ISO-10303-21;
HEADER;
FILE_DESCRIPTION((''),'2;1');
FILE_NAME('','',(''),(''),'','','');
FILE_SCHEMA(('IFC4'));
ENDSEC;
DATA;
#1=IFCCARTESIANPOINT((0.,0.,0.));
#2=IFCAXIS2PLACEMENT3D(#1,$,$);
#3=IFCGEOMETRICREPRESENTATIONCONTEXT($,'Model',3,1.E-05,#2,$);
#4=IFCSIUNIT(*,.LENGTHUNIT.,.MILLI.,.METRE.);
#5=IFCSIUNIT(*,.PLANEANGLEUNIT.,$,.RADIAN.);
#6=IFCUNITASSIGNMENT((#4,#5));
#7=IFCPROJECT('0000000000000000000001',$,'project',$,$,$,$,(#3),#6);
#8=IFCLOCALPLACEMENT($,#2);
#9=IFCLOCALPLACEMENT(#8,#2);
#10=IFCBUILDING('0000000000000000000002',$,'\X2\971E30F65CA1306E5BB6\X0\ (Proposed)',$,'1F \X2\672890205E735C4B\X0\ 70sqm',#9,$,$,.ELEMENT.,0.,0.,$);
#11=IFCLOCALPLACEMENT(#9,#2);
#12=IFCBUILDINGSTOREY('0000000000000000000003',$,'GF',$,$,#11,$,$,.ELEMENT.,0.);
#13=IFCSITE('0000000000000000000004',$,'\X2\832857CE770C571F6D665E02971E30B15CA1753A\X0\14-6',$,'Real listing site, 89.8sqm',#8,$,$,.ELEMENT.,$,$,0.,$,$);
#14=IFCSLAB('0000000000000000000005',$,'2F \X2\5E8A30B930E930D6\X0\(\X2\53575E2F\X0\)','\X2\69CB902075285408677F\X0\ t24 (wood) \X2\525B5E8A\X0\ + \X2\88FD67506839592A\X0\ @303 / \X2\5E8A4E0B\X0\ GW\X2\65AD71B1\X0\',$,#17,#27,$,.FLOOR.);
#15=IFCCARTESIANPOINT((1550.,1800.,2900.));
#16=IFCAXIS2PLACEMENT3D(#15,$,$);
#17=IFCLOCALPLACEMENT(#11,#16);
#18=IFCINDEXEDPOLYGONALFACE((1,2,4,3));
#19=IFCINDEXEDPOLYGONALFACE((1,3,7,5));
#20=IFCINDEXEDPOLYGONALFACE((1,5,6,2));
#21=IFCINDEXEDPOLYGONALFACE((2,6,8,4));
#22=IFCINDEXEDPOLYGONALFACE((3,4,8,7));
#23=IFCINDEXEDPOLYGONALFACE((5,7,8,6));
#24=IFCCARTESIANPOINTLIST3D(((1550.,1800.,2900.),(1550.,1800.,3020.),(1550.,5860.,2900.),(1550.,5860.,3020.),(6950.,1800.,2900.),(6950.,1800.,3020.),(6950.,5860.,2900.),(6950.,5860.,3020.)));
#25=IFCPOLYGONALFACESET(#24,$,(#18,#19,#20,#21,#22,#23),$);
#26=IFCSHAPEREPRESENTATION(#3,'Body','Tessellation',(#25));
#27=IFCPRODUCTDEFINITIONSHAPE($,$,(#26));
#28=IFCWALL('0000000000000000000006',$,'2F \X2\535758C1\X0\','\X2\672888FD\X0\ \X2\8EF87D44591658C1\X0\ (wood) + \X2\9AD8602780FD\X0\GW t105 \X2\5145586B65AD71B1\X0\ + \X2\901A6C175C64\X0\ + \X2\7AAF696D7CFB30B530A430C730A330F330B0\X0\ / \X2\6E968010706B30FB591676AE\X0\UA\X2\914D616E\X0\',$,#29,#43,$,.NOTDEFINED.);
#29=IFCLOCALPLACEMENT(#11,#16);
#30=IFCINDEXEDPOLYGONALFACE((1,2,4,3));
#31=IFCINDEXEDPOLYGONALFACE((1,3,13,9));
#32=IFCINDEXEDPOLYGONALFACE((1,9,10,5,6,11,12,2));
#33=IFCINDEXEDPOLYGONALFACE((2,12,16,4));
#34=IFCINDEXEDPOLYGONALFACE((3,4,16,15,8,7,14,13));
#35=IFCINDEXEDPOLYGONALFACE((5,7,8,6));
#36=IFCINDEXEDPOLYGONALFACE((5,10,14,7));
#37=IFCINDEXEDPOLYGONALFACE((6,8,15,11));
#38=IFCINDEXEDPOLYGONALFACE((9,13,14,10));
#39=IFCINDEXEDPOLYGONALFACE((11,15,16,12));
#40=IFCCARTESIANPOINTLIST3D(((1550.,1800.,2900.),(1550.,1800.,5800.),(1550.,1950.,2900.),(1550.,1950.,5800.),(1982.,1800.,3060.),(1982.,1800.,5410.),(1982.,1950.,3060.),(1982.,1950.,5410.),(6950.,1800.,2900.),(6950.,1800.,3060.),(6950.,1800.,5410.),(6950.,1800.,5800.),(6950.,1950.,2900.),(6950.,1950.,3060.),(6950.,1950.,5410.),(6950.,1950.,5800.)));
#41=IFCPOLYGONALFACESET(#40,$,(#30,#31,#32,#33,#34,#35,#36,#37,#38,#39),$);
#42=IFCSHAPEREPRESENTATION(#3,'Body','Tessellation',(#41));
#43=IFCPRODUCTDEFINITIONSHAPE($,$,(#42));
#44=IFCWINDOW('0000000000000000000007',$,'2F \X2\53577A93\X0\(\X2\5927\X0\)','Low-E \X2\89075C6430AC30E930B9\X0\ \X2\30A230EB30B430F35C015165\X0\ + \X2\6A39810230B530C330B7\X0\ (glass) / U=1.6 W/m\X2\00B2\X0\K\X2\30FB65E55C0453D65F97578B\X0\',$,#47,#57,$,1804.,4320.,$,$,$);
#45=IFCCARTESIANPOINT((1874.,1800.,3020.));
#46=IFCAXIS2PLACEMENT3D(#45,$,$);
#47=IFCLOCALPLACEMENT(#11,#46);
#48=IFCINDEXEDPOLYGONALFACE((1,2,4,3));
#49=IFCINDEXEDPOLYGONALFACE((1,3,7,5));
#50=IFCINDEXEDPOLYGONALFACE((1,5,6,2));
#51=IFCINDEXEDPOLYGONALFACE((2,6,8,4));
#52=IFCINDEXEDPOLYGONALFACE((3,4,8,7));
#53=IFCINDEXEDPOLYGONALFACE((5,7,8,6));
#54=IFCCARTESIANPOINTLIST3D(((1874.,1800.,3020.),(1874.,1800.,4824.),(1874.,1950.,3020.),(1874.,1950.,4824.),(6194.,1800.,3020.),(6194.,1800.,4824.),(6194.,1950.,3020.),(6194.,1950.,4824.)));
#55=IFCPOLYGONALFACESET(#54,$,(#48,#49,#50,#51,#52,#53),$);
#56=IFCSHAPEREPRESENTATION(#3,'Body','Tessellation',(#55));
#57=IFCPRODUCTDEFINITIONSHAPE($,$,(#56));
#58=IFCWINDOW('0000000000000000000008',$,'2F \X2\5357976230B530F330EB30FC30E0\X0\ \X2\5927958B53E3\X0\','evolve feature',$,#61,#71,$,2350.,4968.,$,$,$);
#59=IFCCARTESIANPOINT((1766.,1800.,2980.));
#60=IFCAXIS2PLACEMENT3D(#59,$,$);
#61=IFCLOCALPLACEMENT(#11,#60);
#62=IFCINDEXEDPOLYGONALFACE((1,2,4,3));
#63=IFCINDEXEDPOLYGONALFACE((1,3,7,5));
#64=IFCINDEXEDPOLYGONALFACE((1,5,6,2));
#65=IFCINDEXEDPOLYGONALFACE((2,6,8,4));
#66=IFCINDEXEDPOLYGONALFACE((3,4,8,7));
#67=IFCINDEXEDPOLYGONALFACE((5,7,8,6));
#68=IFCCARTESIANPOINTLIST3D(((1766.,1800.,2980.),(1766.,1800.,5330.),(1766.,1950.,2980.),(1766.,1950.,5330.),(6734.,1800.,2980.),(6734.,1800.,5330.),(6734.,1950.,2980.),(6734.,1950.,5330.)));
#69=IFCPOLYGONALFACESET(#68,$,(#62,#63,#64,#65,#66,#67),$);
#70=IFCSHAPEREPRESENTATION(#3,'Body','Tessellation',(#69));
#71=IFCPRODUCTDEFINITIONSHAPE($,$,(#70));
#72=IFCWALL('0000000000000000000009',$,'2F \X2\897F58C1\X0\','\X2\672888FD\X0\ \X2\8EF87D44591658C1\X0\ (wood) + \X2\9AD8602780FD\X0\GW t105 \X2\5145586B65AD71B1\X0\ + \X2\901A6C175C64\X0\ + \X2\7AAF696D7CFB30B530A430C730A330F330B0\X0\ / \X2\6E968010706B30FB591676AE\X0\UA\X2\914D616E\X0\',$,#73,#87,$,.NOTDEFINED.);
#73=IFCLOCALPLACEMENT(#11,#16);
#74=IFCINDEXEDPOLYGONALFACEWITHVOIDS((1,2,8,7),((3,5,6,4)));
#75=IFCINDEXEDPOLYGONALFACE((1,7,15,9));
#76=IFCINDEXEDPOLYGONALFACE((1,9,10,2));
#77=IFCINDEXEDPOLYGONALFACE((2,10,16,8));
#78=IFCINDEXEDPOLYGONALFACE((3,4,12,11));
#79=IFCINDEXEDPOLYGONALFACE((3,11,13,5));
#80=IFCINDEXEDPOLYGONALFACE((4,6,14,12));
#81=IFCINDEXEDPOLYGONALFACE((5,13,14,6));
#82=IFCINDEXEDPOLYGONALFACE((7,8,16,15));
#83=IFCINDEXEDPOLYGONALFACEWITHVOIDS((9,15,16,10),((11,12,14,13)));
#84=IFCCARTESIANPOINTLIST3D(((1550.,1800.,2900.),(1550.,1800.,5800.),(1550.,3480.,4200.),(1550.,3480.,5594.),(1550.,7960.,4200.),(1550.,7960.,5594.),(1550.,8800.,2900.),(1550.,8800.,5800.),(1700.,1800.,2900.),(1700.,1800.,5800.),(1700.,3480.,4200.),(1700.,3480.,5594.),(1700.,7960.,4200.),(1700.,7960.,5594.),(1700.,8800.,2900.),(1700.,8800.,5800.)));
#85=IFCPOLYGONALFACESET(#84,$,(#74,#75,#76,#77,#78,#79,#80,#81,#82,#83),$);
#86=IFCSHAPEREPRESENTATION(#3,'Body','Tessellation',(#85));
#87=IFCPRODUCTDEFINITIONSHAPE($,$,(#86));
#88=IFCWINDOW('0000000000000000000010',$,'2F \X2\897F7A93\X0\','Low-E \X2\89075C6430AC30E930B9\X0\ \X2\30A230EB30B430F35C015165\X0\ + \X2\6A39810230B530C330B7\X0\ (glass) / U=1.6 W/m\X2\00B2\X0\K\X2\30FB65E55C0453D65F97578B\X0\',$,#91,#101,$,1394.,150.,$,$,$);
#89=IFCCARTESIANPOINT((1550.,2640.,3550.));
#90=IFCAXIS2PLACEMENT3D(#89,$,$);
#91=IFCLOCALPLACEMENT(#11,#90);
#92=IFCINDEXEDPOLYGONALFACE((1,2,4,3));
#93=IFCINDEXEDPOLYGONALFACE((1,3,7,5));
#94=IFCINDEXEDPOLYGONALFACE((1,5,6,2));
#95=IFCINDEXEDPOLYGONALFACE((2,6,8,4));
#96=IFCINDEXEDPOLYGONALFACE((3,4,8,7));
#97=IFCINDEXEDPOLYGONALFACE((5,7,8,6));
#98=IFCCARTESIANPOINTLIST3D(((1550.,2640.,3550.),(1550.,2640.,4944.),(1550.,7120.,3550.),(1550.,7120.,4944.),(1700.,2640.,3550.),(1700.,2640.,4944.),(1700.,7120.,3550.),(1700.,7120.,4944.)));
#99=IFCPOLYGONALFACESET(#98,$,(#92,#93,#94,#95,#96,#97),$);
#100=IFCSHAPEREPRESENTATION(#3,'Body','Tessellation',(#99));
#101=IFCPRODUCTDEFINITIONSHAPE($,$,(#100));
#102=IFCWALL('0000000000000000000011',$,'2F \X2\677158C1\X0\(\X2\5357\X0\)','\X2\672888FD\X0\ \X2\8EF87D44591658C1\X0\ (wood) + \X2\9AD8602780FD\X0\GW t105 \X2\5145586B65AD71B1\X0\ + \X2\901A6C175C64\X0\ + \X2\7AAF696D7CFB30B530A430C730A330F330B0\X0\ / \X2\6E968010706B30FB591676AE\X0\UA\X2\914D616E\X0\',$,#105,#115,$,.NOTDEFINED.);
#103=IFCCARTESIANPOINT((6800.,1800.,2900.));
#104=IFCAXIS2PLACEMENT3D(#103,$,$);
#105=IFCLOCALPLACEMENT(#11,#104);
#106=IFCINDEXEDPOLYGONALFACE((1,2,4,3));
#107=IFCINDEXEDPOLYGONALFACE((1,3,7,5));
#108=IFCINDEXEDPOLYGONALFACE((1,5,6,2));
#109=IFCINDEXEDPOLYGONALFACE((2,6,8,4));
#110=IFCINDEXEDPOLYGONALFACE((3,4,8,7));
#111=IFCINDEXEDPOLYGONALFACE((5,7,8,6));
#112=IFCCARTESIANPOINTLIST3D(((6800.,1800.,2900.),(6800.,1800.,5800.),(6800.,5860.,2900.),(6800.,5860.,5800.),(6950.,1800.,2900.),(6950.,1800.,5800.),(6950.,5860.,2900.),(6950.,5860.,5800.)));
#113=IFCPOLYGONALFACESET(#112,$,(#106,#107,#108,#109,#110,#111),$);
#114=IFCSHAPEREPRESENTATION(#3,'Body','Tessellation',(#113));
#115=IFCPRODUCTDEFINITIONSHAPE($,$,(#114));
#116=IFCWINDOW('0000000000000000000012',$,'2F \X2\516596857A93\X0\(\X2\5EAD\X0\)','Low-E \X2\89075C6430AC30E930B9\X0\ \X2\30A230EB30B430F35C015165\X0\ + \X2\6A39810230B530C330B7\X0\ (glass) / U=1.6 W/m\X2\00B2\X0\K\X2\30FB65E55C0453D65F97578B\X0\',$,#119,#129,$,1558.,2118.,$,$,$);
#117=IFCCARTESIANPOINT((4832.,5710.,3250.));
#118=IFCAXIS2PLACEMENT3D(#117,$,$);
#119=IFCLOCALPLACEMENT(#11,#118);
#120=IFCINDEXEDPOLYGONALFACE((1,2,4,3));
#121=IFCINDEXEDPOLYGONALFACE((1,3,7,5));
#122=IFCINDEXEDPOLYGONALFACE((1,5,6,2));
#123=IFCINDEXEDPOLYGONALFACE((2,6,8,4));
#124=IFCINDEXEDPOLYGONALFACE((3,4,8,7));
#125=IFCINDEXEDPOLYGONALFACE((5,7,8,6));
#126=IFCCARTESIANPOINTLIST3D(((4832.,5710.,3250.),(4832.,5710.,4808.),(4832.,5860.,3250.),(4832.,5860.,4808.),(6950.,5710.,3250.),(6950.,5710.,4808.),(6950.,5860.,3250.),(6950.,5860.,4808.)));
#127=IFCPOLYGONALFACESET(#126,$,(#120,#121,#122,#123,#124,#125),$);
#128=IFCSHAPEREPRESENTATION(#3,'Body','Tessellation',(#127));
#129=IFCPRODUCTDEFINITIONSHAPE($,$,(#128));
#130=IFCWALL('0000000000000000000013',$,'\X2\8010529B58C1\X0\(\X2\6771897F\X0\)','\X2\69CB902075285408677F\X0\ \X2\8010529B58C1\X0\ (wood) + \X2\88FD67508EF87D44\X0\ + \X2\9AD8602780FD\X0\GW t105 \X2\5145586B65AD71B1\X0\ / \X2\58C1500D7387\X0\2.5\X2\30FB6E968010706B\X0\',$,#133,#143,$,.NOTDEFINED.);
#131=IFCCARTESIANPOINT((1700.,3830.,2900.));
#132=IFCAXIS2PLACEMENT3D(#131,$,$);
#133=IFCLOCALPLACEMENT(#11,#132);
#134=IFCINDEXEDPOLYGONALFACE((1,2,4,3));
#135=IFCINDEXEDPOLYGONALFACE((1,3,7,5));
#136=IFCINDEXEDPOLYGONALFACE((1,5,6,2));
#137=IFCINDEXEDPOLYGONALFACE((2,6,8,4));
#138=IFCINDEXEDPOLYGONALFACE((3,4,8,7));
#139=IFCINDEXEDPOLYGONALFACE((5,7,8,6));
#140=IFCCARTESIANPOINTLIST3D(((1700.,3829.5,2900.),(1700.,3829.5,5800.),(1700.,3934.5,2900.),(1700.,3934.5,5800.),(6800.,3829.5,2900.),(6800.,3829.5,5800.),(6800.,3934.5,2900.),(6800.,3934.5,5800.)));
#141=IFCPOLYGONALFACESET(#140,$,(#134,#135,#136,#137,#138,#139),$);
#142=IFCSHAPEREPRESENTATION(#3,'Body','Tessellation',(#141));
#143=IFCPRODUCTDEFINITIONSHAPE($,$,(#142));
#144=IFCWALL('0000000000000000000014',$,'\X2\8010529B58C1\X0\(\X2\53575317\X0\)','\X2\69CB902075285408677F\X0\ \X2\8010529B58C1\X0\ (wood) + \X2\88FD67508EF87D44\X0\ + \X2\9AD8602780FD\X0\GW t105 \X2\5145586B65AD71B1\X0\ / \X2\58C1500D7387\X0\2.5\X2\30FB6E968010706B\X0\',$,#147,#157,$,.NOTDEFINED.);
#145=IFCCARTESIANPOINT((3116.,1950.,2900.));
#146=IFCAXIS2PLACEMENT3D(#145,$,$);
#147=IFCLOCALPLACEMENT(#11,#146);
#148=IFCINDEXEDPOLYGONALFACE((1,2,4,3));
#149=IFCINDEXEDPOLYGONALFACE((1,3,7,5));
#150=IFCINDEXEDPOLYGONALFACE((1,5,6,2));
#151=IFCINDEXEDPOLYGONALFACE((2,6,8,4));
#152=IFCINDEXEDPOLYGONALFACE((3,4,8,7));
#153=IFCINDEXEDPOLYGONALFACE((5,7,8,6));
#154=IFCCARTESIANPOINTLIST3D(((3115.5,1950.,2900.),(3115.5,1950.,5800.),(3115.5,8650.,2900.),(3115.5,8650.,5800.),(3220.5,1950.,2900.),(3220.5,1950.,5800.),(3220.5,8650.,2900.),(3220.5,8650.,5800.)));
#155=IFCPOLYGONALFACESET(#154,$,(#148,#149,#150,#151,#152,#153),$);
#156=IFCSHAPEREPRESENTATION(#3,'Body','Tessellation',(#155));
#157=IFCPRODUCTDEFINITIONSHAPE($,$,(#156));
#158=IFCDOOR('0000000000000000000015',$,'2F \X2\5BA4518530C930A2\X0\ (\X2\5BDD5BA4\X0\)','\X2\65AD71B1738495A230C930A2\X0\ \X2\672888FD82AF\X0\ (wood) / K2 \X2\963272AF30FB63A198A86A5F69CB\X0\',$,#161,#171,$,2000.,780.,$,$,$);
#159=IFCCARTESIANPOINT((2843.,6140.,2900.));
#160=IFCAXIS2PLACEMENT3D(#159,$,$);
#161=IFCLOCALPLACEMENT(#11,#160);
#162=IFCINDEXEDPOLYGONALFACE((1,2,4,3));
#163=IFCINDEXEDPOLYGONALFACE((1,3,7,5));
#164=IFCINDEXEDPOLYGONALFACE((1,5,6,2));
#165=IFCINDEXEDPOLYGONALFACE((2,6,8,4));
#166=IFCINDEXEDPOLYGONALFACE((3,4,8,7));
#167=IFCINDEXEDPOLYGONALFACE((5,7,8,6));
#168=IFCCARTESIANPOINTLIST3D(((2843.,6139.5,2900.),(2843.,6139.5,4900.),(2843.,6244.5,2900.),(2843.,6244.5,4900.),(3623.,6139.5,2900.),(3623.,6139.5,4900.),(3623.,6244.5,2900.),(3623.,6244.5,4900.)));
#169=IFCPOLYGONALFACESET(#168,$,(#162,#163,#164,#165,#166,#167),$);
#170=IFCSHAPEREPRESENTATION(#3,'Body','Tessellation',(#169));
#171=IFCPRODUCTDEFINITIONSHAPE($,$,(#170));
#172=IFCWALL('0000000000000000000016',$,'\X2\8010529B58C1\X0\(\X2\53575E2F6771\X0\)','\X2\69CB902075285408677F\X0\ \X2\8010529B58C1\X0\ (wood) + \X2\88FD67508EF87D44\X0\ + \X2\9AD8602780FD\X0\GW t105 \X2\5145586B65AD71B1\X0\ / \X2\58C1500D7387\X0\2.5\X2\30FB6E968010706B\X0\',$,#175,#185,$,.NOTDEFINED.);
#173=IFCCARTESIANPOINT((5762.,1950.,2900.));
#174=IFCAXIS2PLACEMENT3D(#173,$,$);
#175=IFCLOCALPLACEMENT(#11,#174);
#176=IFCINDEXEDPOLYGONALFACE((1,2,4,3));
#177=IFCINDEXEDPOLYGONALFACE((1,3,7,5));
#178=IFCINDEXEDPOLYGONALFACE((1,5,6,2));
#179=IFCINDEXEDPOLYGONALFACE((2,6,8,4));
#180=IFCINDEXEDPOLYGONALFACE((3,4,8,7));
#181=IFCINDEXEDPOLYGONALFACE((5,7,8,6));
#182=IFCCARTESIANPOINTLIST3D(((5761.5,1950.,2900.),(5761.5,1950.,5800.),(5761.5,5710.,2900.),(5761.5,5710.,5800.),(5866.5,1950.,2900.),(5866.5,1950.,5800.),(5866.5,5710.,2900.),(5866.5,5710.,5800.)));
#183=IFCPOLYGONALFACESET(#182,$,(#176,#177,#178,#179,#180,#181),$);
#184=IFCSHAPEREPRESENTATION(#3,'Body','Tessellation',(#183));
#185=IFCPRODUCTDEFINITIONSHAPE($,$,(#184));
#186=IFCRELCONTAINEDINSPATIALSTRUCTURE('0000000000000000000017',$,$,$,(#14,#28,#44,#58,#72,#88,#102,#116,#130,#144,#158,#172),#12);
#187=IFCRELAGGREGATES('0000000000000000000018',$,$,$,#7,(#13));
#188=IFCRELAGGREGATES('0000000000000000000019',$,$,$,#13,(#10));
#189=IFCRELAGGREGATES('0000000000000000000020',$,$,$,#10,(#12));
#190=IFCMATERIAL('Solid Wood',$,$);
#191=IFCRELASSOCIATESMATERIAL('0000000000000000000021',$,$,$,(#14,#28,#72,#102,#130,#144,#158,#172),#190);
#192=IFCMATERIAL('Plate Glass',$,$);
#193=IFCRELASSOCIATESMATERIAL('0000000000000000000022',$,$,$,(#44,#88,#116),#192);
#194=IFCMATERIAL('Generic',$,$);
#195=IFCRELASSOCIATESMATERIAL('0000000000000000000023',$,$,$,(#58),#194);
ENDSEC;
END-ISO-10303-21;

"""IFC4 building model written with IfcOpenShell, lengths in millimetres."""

from ifc_helpers import new_model, si_unit, frame, frame_2d, origin, place, context, project, spatial, rectangle, extrude, material, element, fill, save


model = new_model("IFC4")

# Units and contexts
model_context = context("Model", 3, precision=1e-05, world=origin())
ifc_project = project(units=[si_unit("LENGTHUNIT", "METRE", prefix="MILLI"), si_unit("PLANEANGLEUNIT", "RADIAN")], contexts=[model_context])

# Site, building, storey
site_placement = place(None, origin())
site = spatial("IfcSite", under=ifc_project, at=site_placement, Name="茨城県土浦市霞ケ岡町14-6", ObjectType="Real listing site, 89.8sqm", CompositionType="ELEMENT", RefElevation=0.0)
building_placement = place(site_placement, origin())
building = spatial("IfcBuilding", under=site, at=building_placement, Name="霞ヶ岡の家 (Proposed)", ObjectType="1F 木造平屋 70sqm", CompositionType="ELEMENT", ElevationOfRefHeight=0.0, ElevationOfTerrain=0.0)
storey_placement = place(building_placement, origin())
storey = spatial("IfcBuildingStorey", under=building, at=storey_placement, Name="GF", CompositionType="ELEMENT", Elevation=0.0)

# Slab
ifc_material_1 = material(Name="Solid Wood")
slab_placement = place(storey_placement, frame((1550.0, 1800.0, 2900.0)))
element("IfcSlab", 1, at=slab_placement, inside=storey, material=ifc_material_1, Name="2F 床スラブ(南帯)", Description="構造用合板 t24 (wood) 剛床 + 製材根太 @303 / 床下 GW断熱", PredefinedType="FLOOR", context=model_context, shape_type="SweptSolid", body=[
    extrude(rectangle(XDim=5400.0, YDim=4060.0, at=frame_2d((2700.0, 2030.0))), frame((1550.0, 1800.0, 2900.0)), (0.0, 0.0, 1.0), 120.0),
])

# Wall, openings, windows
wall_1_placement = place(storey_placement, frame((1550.0, 1800.0, 2900.0)))
wall_1 = element("IfcWall", 2, at=wall_1_placement, inside=storey, material=ifc_material_1, Name="2F 南壁", Description="木製 軸組外壁 (wood) + 高性能GW t105 充填断熱 + 通気層 + 窯業系サイディング / 準耐火・外皮UA配慮", PredefinedType="NOTDEFINED", context=model_context, shape_type="SweptSolid", body=[
    extrude(rectangle(XDim=5400.0, YDim=150.0, at=frame_2d((2700.0, 75.0))), frame((1550.0, 1800.0, 2900.0)), (0.0, 0.0, 1.0), 2900.0),
])
opening_1_placement = place(storey_placement, frame((1874.0, 1800.0, 3020.0)))
opening_1 = element("IfcOpeningElement", 3, at=opening_1_placement, cuts=wall_1, PredefinedType="NOTDEFINED", context=model_context, shape_type="SweptSolid", body=[
    extrude(rectangle(XDim=4320.0, YDim=150.0, at=frame_2d((2160.0, 75.0))), frame((1874.0, 1800.0, 3020.0)), (0.0, 0.0, 1.0), 1804.0),
])
opening_2_placement = place(storey_placement, frame((1766.0, 1800.0, 2980.0)))
opening_2 = element("IfcOpeningElement", 4, at=opening_2_placement, cuts=wall_1, PredefinedType="NOTDEFINED", context=model_context, shape_type="SweptSolid", body=[
    extrude(rectangle(XDim=4968.0, YDim=150.0, at=frame_2d((2484.0, 75.0))), frame((1766.0, 1800.0, 2980.0)), (0.0, 0.0, 1.0), 2350.0),
])
ifc_material_2 = material(Name="Plate Glass")
window_1_placement = place(storey_placement, frame((1874.0, 1800.0, 3020.0)))
window_1 = element("IfcWindow", 5, at=window_1_placement, inside=storey, material=ifc_material_2, Name="2F 南窓(大)", Description="Low-E 複層ガラス アルゴン封入 + 樹脂サッシ (glass) / U=1.6 W/m²K・日射取得型", OverallHeight=1804.0, OverallWidth=4320.0, context=model_context, shape_type="SweptSolid", body=[
    extrude(rectangle(XDim=4320.0, YDim=150.0, at=frame_2d((2160.0, 75.0))), frame((1874.0, 1800.0, 3020.0)), (0.0, 0.0, 1.0), 1804.0),
])
fill(opening_1, window_1)
ifc_material_3 = material(Name="Generic")
window_2_placement = place(storey_placement, frame((1766.0, 1800.0, 2980.0)))
window_2 = element("IfcWindow", 6, at=window_2_placement, inside=storey, material=ifc_material_3, Name="2F 南面サンルーム 大開口", Description="evolve feature", OverallHeight=2350.0, OverallWidth=4968.0, context=model_context, shape_type="SweptSolid", body=[
    extrude(rectangle(XDim=4968.0, YDim=150.0, at=frame_2d((2484.0, 75.0))), frame((1766.0, 1800.0, 2980.0)), (0.0, 0.0, 1.0), 2350.0),
])
fill(opening_2, window_2)

# Walls, openings, windows
wall_2_placement = place(storey_placement, frame((1550.0, 1800.0, 2900.0)))
wall_2 = element("IfcWall", 7, at=wall_2_placement, inside=storey, material=ifc_material_1, Name="2F 西壁", Description="木製 軸組外壁 (wood) + 高性能GW t105 充填断熱 + 通気層 + 窯業系サイディング / 準耐火・外皮UA配慮", PredefinedType="NOTDEFINED", context=model_context, shape_type="SweptSolid", body=[
    extrude(rectangle(XDim=150.0, YDim=7000.0, at=frame_2d((75.0, 3500.0))), frame((1550.0, 1800.0, 2900.0)), (0.0, 0.0, 1.0), 2900.0),
])
opening_3_placement = place(storey_placement, frame((1550.0, 2640.0, 3550.0)))
opening_3 = element("IfcOpeningElement", 8, at=opening_3_placement, cuts=wall_2, PredefinedType="NOTDEFINED", context=model_context, shape_type="SweptSolid", body=[
    extrude(rectangle(XDim=150.0, YDim=4480.0, at=frame_2d((75.0, 2240.0))), frame((1550.0, 2640.0, 3550.0)), (0.0, 0.0, 1.0), 1394.0),
])
window_3_placement = place(storey_placement, frame((1550.0, 2640.0, 3550.0)))
window_3 = element("IfcWindow", 9, at=window_3_placement, inside=storey, material=ifc_material_2, Name="2F 西窓", Description="Low-E 複層ガラス アルゴン封入 + 樹脂サッシ (glass) / U=1.6 W/m²K・日射取得型", OverallHeight=1394.0, OverallWidth=150.0, context=model_context, shape_type="SweptSolid", body=[
    extrude(rectangle(XDim=150.0, YDim=4480.0, at=frame_2d((75.0, 2240.0))), frame((1550.0, 2640.0, 3550.0)), (0.0, 0.0, 1.0), 1394.0),
])
fill(opening_3, window_3)
wall_3_placement = place(storey_placement, frame((6800.0, 1800.0, 2900.0)))
wall_3 = element("IfcWall", 10, at=wall_3_placement, inside=storey, material=ifc_material_1, Name="2F 東壁(南)", Description="木製 軸組外壁 (wood) + 高性能GW t105 充填断熱 + 通気層 + 窯業系サイディング / 準耐火・外皮UA配慮", PredefinedType="NOTDEFINED", context=model_context, shape_type="SweptSolid", body=[
    extrude(rectangle(XDim=150.0, YDim=4060.0, at=frame_2d((75.0, 2030.0))), frame((6800.0, 1800.0, 2900.0)), (0.0, 0.0, 1.0), 2900.0),
])
opening_4_placement = place(storey_placement, frame((4832.0, 5710.0, 3250.0)))
opening_4 = element("IfcOpeningElement", 11, at=opening_4_placement, cuts=wall_3, PredefinedType="NOTDEFINED", context=model_context, shape_type="SweptSolid", body=[
    extrude(rectangle(XDim=2118.0, YDim=150.0, at=frame_2d((1059.0, 75.0))), frame((4832.0, 5710.0, 3250.0)), (0.0, 0.0, 1.0), 1558.0),
])
window_4_placement = place(storey_placement, frame((4832.0, 5710.0, 3250.0)))
window_4 = element("IfcWindow", 12, at=window_4_placement, inside=storey, material=ifc_material_2, Name="2F 入隅窓(庭)", Description="Low-E 複層ガラス アルゴン封入 + 樹脂サッシ (glass) / U=1.6 W/m²K・日射取得型", OverallHeight=1558.0, OverallWidth=2118.0, context=model_context, shape_type="SweptSolid", body=[
    extrude(rectangle(XDim=2118.0, YDim=150.0, at=frame_2d((1059.0, 75.0))), frame((4832.0, 5710.0, 3250.0)), (0.0, 0.0, 1.0), 1558.0),
])
fill(opening_4, window_4)

# Wall
wall_4_placement = place(storey_placement, frame((1700.0, 3830.0, 2900.0)))
element("IfcWall", 13, at=wall_4_placement, inside=storey, material=ifc_material_1, Name="耐力壁(東西)", Description="構造用合板 耐力壁 (wood) + 製材軸組 + 高性能GW t105 充填断熱 / 壁倍率2.5・準耐火", PredefinedType="NOTDEFINED", context=model_context, shape_type="SweptSolid", body=[
    extrude(rectangle(XDim=5100.0, YDim=105.0, at=frame_2d((2550.0, 52.0))), frame((1700.0, 3830.0, 2900.0)), (0.0, 0.0, 1.0), 2900.0),
])

# Wall, opening, door
wall_5_placement = place(storey_placement, frame((3116.0, 1950.0, 2900.0)))
wall_5 = element("IfcWall", 14, at=wall_5_placement, inside=storey, material=ifc_material_1, Name="耐力壁(南北)", Description="構造用合板 耐力壁 (wood) + 製材軸組 + 高性能GW t105 充填断熱 / 壁倍率2.5・準耐火", PredefinedType="NOTDEFINED", context=model_context, shape_type="SweptSolid", body=[
    extrude(rectangle(XDim=105.0, YDim=6700.0, at=frame_2d((52.0, 3350.0))), frame((3116.0, 1950.0, 2900.0)), (0.0, 0.0, 1.0), 2900.0),
])
opening_5_placement = place(storey_placement, frame((2843.0, 6140.0, 2900.0)))
opening_5 = element("IfcOpeningElement", 15, at=opening_5_placement, cuts=wall_5, PredefinedType="NOTDEFINED", context=model_context, shape_type="SweptSolid", body=[
    extrude(rectangle(XDim=780.0, YDim=105.0, at=frame_2d((390.0, 52.0))), frame((2843.0, 6140.0, 2900.0)), (0.0, 0.0, 1.0), 2000.0),
])
door_placement = place(storey_placement, frame((2843.0, 6140.0, 2900.0)))
door = element("IfcDoor", 16, at=door_placement, inside=storey, material=ifc_material_1, Name="2F 室内ドア (寝室)", Description="断熱玄関ドア 木製芯 (wood) / K2 防犯・採風機構", OverallHeight=2000.0, OverallWidth=780.0, context=model_context, shape_type="SweptSolid", body=[
    extrude(rectangle(XDim=780.0, YDim=105.0, at=frame_2d((390.0, 52.0))), frame((2843.0, 6140.0, 2900.0)), (0.0, 0.0, 1.0), 2000.0),
])
fill(opening_5, door)

# Wall
wall_6_placement = place(storey_placement, frame((5762.0, 1950.0, 2900.0)))
element("IfcWall", 17, at=wall_6_placement, inside=storey, material=ifc_material_1, Name="耐力壁(南帯東)", Description="構造用合板 耐力壁 (wood) + 製材軸組 + 高性能GW t105 充填断熱 / 壁倍率2.5・準耐火", PredefinedType="NOTDEFINED", context=model_context, shape_type="SweptSolid", body=[
    extrude(rectangle(XDim=105.0, YDim=3760.0, at=frame_2d((52.0, 1880.0))), frame((5762.0, 1950.0, 2900.0)), (0.0, 0.0, 1.0), 2900.0),
])

save(model, "model.ifc")
